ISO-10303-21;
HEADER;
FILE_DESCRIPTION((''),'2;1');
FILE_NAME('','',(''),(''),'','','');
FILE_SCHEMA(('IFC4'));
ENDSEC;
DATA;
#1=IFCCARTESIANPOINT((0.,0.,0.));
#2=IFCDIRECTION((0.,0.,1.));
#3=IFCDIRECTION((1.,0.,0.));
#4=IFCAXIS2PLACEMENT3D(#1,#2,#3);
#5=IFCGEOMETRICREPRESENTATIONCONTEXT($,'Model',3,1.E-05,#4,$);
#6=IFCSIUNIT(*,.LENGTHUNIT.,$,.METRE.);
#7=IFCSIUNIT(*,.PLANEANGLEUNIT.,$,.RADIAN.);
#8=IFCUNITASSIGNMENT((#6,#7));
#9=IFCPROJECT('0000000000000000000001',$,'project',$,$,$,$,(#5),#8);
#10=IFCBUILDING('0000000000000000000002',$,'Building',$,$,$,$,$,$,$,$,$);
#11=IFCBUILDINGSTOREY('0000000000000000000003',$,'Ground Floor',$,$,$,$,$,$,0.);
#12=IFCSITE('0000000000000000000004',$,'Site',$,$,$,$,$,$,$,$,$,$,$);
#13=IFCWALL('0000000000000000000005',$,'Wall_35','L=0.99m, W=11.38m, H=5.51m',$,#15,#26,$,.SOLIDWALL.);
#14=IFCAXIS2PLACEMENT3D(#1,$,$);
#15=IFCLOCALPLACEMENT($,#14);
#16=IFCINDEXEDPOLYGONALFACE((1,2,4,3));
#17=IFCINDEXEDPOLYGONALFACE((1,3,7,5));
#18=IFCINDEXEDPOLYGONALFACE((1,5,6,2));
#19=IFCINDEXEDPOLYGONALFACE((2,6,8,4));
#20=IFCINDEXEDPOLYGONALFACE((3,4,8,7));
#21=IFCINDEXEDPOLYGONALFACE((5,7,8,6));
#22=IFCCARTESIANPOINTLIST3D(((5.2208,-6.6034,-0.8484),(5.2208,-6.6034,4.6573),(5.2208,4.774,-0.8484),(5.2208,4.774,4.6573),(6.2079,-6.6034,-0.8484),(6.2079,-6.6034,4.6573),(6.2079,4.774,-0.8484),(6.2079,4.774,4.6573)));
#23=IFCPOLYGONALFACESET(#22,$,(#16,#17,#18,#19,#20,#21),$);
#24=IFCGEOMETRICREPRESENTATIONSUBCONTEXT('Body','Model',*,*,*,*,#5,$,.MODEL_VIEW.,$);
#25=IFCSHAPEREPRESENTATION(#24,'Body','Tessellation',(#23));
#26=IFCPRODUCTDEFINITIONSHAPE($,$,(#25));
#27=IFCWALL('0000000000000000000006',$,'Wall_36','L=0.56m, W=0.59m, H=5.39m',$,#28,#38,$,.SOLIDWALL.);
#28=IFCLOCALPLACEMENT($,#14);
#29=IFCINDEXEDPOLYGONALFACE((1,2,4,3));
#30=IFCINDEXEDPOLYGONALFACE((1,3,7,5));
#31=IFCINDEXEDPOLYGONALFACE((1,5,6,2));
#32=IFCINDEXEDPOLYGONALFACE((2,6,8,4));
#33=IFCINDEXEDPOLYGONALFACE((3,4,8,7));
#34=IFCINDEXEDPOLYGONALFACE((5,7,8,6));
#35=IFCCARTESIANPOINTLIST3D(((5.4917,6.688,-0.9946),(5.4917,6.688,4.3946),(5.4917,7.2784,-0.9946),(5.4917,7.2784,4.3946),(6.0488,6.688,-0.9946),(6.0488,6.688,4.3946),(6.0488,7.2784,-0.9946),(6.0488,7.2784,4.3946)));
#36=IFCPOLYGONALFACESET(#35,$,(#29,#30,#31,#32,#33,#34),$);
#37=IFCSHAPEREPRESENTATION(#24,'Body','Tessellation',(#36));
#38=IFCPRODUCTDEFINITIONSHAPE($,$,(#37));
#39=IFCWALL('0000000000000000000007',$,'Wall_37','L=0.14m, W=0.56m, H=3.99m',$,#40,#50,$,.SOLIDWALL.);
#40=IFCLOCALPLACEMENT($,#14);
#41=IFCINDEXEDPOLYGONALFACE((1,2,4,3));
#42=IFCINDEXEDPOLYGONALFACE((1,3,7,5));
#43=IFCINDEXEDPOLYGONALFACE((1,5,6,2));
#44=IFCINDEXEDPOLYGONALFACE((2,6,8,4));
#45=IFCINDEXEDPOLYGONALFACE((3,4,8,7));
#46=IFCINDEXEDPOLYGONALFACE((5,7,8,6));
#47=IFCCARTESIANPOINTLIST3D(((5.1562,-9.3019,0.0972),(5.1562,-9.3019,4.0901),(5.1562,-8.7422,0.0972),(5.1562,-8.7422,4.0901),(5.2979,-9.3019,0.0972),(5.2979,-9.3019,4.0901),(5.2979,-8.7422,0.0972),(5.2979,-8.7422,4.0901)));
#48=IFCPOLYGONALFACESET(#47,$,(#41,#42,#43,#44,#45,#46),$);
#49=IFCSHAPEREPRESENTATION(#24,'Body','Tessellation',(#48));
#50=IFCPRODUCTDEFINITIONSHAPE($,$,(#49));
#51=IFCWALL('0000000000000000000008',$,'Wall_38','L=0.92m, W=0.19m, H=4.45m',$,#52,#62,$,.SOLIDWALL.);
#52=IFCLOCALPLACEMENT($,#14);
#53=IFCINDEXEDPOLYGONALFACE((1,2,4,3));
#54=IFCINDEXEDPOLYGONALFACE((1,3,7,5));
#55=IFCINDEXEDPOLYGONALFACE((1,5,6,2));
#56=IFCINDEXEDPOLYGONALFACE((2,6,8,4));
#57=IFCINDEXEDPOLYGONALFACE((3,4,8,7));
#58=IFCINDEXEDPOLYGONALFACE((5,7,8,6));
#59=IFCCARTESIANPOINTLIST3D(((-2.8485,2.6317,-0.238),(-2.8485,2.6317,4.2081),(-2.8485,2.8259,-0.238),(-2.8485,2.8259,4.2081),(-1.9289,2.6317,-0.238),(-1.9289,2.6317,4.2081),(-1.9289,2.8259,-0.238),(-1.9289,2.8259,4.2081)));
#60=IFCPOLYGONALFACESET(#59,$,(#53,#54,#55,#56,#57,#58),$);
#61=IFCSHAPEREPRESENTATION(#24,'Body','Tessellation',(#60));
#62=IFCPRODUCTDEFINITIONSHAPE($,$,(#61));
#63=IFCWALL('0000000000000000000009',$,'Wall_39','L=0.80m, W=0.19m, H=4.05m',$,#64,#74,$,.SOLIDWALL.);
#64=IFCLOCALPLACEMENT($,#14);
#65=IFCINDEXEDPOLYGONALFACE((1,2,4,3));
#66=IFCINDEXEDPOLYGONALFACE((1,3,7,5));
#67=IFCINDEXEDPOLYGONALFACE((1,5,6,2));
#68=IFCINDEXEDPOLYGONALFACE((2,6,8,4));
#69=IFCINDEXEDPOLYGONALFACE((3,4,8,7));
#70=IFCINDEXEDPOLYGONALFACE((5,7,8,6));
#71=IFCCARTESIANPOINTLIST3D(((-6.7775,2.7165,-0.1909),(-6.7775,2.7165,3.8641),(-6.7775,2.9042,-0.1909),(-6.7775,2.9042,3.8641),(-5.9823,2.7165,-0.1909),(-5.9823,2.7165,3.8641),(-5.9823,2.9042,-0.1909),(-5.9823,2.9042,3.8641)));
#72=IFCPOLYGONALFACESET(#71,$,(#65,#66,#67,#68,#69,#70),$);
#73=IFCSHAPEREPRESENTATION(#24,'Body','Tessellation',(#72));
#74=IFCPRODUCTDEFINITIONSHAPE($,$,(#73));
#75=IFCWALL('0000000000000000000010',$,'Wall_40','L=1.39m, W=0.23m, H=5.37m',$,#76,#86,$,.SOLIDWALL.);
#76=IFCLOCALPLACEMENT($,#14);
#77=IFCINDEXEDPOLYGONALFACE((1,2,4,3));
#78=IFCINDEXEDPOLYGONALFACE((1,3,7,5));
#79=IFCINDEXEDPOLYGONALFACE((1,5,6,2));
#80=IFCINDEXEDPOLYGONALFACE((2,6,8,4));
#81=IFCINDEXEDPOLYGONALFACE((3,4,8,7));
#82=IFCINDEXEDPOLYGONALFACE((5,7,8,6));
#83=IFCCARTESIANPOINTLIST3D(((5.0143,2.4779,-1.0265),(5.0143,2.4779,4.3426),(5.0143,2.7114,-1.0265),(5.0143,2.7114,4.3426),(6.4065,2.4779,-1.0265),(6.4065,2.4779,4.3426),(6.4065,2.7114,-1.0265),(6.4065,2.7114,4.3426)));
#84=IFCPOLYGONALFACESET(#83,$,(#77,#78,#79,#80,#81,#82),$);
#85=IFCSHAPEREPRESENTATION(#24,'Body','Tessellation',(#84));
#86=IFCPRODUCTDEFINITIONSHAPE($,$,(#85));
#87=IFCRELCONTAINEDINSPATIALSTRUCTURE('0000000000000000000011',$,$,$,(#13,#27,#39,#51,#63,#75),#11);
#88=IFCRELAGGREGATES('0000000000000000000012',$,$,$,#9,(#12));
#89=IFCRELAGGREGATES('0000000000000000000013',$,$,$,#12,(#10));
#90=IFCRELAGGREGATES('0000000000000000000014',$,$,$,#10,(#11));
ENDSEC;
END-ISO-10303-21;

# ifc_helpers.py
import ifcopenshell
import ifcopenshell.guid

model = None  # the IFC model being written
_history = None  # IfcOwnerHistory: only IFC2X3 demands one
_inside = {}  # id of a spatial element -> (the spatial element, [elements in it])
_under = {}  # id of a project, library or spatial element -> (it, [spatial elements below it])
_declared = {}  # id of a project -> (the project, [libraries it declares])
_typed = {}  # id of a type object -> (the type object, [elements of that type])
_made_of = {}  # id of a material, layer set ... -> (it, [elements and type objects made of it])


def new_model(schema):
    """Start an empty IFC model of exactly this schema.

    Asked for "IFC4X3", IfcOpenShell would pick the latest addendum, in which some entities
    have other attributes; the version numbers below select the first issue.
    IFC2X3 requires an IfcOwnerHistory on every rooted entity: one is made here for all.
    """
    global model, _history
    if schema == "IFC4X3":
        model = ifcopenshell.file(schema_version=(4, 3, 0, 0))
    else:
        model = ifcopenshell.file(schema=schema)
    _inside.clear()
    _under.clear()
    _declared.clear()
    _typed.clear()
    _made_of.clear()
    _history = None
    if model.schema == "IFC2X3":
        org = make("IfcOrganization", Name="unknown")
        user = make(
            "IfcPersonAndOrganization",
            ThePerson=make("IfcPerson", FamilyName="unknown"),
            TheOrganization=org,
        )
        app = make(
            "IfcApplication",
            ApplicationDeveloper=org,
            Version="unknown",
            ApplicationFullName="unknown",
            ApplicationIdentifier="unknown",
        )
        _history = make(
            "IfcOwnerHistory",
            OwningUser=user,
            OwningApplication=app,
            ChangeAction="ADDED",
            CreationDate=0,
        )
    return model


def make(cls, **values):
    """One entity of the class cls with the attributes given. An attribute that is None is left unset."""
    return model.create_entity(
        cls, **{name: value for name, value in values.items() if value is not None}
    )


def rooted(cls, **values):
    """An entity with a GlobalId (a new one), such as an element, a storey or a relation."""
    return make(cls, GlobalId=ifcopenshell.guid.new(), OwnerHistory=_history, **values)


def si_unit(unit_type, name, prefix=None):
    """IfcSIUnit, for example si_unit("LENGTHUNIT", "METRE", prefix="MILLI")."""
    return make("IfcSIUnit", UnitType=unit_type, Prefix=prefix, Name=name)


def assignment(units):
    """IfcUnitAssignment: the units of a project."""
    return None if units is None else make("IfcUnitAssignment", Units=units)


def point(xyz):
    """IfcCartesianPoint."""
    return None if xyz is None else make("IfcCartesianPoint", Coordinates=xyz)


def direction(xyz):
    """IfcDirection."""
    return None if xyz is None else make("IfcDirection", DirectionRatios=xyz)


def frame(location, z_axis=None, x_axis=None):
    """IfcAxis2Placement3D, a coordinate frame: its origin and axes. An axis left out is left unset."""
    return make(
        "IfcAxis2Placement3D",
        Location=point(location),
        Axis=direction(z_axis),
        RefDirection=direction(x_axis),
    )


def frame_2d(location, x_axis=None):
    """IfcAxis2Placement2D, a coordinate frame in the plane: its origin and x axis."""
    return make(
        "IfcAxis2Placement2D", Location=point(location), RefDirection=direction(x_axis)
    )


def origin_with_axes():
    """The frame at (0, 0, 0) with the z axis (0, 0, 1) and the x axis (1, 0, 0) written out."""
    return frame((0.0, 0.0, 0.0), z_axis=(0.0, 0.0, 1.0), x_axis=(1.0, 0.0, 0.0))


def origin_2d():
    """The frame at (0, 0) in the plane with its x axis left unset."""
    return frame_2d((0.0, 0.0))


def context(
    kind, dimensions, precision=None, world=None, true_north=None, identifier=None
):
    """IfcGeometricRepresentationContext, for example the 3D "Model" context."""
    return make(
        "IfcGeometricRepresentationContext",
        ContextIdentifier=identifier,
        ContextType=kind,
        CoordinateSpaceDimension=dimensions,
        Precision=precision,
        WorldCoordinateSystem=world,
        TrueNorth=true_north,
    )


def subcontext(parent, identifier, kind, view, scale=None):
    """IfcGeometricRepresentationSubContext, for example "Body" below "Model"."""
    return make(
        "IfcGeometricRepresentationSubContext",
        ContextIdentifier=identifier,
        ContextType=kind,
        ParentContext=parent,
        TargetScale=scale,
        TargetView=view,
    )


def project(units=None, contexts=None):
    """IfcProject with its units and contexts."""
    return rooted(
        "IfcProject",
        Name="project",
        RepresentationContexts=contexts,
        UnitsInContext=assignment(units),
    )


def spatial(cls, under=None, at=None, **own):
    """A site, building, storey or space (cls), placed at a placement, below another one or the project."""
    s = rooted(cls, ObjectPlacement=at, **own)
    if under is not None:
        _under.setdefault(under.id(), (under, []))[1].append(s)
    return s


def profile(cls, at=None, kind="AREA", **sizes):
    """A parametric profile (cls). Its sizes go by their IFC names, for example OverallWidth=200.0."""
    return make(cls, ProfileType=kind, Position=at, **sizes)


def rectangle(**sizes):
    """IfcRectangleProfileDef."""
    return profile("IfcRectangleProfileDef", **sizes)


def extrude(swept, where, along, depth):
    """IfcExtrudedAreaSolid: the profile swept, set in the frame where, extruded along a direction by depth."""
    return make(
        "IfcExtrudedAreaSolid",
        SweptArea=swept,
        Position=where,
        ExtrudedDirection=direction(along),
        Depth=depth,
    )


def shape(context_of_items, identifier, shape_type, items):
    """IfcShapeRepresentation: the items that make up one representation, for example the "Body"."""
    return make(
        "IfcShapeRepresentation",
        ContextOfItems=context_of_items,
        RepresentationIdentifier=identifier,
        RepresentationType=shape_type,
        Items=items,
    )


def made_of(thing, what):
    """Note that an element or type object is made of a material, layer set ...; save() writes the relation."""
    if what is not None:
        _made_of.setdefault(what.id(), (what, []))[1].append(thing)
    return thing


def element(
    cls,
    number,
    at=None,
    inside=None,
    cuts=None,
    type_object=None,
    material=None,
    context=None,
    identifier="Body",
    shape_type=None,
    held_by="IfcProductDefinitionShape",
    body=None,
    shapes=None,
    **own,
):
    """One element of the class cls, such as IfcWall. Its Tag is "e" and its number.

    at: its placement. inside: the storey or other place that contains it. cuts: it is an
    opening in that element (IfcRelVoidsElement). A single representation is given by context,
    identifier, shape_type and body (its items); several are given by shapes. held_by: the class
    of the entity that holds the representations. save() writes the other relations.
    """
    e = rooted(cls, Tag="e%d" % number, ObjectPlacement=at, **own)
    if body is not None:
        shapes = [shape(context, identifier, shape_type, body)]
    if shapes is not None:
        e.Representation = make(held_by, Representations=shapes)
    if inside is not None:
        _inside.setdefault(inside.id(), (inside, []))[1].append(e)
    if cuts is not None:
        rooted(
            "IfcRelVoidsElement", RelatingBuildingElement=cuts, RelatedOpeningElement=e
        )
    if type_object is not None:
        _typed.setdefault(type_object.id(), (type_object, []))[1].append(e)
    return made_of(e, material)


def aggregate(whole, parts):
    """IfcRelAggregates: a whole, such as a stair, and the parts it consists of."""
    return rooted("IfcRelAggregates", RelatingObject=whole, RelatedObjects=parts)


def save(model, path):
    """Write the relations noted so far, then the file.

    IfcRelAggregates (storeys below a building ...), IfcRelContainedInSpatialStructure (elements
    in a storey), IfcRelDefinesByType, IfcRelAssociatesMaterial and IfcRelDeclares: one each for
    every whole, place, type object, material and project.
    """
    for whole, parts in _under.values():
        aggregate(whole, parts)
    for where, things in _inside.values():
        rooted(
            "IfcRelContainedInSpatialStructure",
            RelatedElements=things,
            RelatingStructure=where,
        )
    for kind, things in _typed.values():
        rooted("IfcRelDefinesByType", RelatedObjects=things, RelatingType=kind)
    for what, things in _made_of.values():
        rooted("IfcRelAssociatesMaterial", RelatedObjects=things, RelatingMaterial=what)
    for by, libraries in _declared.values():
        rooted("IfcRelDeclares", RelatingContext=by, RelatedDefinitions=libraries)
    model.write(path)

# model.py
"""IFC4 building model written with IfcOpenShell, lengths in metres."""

from ifc_helpers import new_model, si_unit, frame, origin_with_axes, origin_2d, context, subcontext, project, spatial, rectangle, extrude, element, save


model = new_model("IFC4")

# Units and contexts
model_context = context("Model", 3, precision=1e-05, world=origin_with_axes())
body_context = subcontext(model_context, "Body", "Model", "MODEL_VIEW")
ifc_project = project(units=[si_unit("LENGTHUNIT", "METRE"), si_unit("PLANEANGLEUNIT", "RADIAN")], contexts=[model_context])

# Site, building, storey
site = spatial("IfcSite", under=ifc_project, Name="Site")
building = spatial("IfcBuilding", under=site, Name="Building")
storey = spatial("IfcBuildingStorey", under=building, Name="Ground Floor", Elevation=0.0)

# Walls
element("IfcWall", 1, inside=storey, Name="Wall_35", Description="L=0.99m, W=11.38m, H=5.51m", PredefinedType="SOLIDWALL", context=body_context, shape_type="SweptSolid", body=[
    extrude(rectangle(XDim=0.9872, YDim=11.3773, at=origin_2d()), frame((5.7144, -0.9147, -0.8484), z_axis=(0.0, 0.0, 1.0), x_axis=(1.0, 0.0, 0.0)), (0.0, 0.0, 1.0), 5.5057),
])
element("IfcWall", 2, inside=storey, Name="Wall_36", Description="L=0.56m, W=0.59m, H=5.39m", PredefinedType="SOLIDWALL", context=body_context, shape_type="SweptSolid", body=[
    extrude(rectangle(XDim=0.557, YDim=0.5904, at=origin_2d()), frame((5.7703, 6.9832, -0.9946), z_axis=(0.0, 0.0, 1.0), x_axis=(1.0, 0.0, 0.0)), (0.0, 0.0, 1.0), 5.3891),
])
element("IfcWall", 3, inside=storey, Name="Wall_37", Description="L=0.14m, W=0.56m, H=3.99m", PredefinedType="SOLIDWALL", context=body_context, shape_type="SweptSolid", body=[
    extrude(rectangle(XDim=0.1417, YDim=0.5597, at=origin_2d()), frame((5.227, -9.0221, 0.0972), z_axis=(0.0, 0.0, 1.0), x_axis=(1.0, 0.0, 0.0)), (0.0, 0.0, 1.0), 3.9929),
])
element("IfcWall", 4, inside=storey, Name="Wall_38", Description="L=0.92m, W=0.19m, H=4.45m", PredefinedType="SOLIDWALL", context=body_context, shape_type="SweptSolid", body=[
    extrude(rectangle(XDim=0.9196, YDim=0.1942, at=origin_2d()), frame((-2.3887, 2.7288, -0.238), z_axis=(0.0, 0.0, 1.0), x_axis=(1.0, 0.0, 0.0)), (0.0, 0.0, 1.0), 4.4461),
])
element("IfcWall", 5, inside=storey, Name="Wall_39", Description="L=0.80m, W=0.19m, H=4.05m", PredefinedType="SOLIDWALL", context=body_context, shape_type="SweptSolid", body=[
    extrude(rectangle(XDim=0.7952, YDim=0.1877, at=origin_2d()), frame((-6.3799, 2.8103, -0.1909), z_axis=(0.0, 0.0, 1.0), x_axis=(1.0, 0.0, 0.0)), (0.0, 0.0, 1.0), 4.055),
])
element("IfcWall", 6, inside=storey, Name="Wall_40", Description="L=1.39m, W=0.23m, H=5.37m", PredefinedType="SOLIDWALL", context=body_context, shape_type="SweptSolid", body=[
    extrude(rectangle(XDim=1.3922, YDim=0.2334, at=origin_2d()), frame((5.7104, 2.5946, -1.0265), z_axis=(0.0, 0.0, 1.0), x_axis=(1.0, 0.0, 0.0)), (0.0, 0.0, 1.0), 5.369),
])

save(model, "model.ifc")
